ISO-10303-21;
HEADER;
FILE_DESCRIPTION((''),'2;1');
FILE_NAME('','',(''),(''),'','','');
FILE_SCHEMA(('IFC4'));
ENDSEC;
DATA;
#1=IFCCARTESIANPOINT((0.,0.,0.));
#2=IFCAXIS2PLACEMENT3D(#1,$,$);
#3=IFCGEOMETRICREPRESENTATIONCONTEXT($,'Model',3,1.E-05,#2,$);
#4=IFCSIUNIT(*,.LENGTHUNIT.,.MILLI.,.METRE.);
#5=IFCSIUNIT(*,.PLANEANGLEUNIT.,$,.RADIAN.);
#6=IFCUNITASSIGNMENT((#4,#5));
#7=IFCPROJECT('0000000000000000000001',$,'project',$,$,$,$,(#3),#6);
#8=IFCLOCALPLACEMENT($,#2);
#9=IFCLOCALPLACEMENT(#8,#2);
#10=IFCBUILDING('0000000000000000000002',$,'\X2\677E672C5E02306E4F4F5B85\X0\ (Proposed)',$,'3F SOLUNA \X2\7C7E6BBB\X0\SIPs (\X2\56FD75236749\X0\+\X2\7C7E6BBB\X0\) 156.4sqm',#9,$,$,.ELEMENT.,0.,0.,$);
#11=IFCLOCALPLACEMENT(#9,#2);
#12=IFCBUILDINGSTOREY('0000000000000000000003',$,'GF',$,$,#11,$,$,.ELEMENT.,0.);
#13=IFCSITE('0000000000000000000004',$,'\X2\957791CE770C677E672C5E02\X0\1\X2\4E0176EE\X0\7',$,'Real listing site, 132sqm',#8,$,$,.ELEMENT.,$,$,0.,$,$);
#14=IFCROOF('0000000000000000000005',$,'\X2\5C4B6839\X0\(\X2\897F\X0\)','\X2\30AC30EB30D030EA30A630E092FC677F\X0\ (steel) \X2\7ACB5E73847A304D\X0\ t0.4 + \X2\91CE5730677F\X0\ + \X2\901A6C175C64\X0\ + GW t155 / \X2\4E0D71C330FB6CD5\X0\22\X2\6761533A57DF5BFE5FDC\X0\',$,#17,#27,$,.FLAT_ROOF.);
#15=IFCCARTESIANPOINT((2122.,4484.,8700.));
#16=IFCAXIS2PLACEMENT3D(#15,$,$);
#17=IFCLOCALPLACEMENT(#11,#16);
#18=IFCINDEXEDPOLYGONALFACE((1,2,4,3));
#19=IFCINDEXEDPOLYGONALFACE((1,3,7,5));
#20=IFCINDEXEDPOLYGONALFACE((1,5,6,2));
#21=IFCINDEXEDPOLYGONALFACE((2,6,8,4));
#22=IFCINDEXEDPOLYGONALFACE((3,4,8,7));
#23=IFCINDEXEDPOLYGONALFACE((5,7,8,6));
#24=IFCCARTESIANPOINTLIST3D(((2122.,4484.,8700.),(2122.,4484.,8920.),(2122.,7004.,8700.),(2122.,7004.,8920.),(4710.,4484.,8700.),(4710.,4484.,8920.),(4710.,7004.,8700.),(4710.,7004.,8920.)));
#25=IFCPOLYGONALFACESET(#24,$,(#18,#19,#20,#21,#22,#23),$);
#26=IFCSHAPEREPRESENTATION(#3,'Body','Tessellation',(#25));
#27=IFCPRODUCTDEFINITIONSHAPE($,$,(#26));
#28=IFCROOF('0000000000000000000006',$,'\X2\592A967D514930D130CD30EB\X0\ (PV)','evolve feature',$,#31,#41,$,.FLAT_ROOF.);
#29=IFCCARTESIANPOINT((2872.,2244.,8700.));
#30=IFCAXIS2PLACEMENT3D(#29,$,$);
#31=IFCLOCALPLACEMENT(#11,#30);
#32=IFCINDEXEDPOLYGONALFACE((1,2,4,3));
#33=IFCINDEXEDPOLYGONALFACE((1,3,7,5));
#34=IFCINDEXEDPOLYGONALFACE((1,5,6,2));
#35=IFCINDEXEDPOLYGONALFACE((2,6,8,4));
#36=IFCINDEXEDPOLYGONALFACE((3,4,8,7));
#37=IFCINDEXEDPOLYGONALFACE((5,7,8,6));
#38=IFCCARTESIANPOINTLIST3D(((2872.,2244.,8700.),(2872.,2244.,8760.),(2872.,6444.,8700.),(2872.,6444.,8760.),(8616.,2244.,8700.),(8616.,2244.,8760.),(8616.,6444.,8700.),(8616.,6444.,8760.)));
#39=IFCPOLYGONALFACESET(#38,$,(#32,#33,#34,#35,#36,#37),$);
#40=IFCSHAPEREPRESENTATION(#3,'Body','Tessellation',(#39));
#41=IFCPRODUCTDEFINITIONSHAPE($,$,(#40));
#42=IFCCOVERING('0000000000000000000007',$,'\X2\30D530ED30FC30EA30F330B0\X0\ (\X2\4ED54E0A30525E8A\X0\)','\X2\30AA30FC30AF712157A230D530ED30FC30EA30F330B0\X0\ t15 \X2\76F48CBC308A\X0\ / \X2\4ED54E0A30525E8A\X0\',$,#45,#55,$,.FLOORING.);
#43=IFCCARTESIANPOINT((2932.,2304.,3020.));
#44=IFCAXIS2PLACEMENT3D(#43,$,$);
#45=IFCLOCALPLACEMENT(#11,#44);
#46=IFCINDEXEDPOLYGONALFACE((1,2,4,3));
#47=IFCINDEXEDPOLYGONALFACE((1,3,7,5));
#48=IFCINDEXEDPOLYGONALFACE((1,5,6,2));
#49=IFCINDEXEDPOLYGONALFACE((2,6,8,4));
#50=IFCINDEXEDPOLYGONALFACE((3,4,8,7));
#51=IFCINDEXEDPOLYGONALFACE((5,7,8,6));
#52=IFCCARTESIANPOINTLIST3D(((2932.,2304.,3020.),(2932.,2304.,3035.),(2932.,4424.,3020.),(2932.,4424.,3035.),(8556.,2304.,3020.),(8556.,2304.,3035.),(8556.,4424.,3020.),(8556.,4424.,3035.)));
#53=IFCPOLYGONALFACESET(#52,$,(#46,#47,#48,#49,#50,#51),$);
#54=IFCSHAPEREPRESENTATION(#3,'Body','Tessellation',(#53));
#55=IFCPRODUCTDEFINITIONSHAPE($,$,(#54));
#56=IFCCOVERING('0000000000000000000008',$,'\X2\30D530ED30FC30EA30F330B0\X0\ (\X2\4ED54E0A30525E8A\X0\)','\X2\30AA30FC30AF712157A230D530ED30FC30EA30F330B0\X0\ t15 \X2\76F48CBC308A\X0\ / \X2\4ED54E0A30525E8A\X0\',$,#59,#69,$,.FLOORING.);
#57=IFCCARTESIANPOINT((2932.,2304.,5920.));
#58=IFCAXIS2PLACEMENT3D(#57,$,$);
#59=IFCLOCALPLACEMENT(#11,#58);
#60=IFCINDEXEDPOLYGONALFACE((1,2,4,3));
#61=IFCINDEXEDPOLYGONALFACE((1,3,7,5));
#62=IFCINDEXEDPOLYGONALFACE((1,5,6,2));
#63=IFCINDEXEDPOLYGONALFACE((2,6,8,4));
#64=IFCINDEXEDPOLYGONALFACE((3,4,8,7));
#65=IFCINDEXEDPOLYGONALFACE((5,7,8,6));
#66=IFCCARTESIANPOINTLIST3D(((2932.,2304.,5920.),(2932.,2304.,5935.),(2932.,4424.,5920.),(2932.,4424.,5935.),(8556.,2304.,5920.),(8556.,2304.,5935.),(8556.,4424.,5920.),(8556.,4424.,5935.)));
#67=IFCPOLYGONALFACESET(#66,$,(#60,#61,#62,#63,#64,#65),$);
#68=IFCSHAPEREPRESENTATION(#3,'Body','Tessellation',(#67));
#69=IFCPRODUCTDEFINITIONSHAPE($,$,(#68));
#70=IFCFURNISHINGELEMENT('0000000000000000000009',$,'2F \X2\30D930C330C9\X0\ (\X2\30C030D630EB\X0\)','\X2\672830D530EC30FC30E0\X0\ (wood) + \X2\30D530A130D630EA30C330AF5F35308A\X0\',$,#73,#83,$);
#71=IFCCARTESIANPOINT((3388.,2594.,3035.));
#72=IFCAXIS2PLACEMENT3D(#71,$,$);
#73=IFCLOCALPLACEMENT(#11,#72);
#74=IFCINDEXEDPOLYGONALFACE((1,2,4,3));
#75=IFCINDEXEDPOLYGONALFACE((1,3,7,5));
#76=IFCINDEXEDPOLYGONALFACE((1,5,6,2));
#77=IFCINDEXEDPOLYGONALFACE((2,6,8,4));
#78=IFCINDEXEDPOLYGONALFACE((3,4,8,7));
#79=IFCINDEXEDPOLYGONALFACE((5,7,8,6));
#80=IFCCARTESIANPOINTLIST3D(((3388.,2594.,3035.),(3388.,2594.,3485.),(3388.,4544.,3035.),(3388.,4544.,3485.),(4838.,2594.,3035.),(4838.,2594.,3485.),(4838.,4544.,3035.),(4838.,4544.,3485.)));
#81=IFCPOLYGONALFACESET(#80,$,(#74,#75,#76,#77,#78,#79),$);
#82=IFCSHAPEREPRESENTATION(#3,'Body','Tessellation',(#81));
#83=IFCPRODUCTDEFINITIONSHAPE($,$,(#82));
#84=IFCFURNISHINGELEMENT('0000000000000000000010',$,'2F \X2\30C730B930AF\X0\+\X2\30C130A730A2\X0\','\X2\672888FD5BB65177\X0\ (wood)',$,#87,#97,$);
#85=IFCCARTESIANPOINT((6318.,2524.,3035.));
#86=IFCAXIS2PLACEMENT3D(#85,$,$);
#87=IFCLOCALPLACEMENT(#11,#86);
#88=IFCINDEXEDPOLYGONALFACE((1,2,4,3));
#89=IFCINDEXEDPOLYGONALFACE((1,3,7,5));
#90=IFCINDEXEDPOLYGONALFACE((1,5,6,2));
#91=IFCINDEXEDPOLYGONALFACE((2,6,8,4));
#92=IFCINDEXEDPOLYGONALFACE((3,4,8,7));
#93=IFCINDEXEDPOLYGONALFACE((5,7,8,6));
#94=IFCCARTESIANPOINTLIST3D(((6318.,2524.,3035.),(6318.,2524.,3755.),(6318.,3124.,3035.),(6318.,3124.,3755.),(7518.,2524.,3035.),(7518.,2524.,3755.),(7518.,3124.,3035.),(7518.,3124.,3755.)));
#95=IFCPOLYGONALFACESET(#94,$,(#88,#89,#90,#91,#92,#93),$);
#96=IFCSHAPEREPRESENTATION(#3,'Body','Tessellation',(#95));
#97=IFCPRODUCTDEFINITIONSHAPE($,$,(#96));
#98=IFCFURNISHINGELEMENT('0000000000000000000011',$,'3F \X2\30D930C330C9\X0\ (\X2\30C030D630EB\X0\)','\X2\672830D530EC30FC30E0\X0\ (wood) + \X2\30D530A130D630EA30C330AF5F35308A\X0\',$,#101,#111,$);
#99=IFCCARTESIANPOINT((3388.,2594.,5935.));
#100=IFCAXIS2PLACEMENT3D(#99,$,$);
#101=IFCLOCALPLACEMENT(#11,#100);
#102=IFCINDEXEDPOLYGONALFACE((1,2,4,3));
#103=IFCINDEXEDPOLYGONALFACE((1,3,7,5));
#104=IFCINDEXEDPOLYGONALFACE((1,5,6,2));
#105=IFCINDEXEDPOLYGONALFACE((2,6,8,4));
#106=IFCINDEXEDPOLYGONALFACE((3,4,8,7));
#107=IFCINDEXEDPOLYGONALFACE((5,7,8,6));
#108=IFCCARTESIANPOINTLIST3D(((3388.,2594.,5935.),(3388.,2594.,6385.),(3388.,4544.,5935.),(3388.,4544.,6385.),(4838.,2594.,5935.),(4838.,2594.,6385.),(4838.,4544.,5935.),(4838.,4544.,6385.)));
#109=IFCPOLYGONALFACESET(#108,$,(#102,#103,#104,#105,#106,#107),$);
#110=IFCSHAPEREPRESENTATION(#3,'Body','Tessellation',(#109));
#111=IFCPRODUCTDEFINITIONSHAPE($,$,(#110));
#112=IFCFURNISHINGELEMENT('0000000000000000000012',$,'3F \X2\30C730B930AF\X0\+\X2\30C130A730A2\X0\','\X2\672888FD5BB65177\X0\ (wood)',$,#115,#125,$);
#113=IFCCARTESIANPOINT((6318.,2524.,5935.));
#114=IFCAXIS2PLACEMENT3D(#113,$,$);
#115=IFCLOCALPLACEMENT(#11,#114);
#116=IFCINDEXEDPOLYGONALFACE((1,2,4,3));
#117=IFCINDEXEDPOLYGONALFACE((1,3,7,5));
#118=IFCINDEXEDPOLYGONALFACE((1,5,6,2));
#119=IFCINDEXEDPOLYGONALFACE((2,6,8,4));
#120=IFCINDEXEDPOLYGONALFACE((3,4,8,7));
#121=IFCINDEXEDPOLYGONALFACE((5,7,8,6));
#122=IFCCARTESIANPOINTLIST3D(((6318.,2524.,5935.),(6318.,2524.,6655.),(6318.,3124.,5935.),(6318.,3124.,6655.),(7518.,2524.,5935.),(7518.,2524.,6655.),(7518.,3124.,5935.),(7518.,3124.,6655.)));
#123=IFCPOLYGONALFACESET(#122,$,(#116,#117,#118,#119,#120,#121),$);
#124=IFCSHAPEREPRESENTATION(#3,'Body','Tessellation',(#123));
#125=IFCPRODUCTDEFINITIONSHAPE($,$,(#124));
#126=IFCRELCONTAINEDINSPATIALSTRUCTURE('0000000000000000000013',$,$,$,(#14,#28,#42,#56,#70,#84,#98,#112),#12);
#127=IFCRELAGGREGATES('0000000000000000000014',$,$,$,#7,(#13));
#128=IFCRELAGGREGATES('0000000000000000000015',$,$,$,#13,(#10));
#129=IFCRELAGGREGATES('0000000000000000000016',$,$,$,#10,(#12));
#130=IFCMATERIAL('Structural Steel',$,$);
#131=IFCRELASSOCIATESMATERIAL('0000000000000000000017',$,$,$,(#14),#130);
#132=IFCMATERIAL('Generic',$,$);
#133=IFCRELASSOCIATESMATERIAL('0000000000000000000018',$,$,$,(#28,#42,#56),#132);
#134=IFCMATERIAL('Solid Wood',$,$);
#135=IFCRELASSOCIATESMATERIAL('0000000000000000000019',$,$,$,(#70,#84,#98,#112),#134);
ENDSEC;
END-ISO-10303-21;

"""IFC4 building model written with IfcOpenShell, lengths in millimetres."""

from ifc_helpers import new_model, si_unit, frame, frame_2d, origin, place, context, project, spatial, rectangle, extrude, material, element, save


model = new_model("IFC4")

# Units and contexts
model_context = context("Model", 3, precision=1e-05, world=origin())
ifc_project = project(units=[si_unit("LENGTHUNIT", "METRE", prefix="MILLI"), si_unit("PLANEANGLEUNIT", "RADIAN")], contexts=[model_context])

# Site, building, storey
site_placement = place(None, origin())
site = spatial("IfcSite", under=ifc_project, at=site_placement, Name="長野県松本市1丁目7", ObjectType="Real listing site, 132sqm", CompositionType="ELEMENT", RefElevation=0.0)
building_placement = place(site_placement, origin())
building = spatial("IfcBuilding", under=site, at=building_placement, Name="松本市の住宅 (Proposed)", ObjectType="3F SOLUNA 籾殻SIPs (国産杉+籾殻) 156.4sqm", CompositionType="ELEMENT", ElevationOfRefHeight=0.0, ElevationOfTerrain=0.0)
storey_placement = place(building_placement, origin())
storey = spatial("IfcBuildingStorey", under=building, at=storey_placement, Name="GF", CompositionType="ELEMENT", Elevation=0.0)

# Shared definitions
ifc_material_1 = material(Name="Solid Wood")

# Roofs
ifc_material_2 = material(Name="Structural Steel")
roof_1_placement = place(storey_placement, frame((2122.0, 4484.0, 8700.0)))
element("IfcRoof", 1, at=roof_1_placement, inside=storey, material=ifc_material_2, Name="屋根(西)", Description="ガルバリウム鋼板 (steel) 立平葺き t0.4 + 野地板 + 通気層 + GW t155 / 不燃・法22条区域対応", PredefinedType="FLAT_ROOF", context=model_context, shape_type="SweptSolid", body=[
    extrude(rectangle(XDim=2588.0, YDim=2520.0, at=frame_2d((1294.0, 1260.0))), frame((2122.0, 4484.0, 8700.0)), (0.0, 0.0, 1.0), 220.0),
])
ifc_material_3 = material(Name="Generic")
roof_2_placement = place(storey_placement, frame((2872.0, 2244.0, 8700.0)))
element("IfcRoof", 2, at=roof_2_placement, inside=storey, material=ifc_material_3, Name="太陽光パネル (PV)", Description="evolve feature", PredefinedType="FLAT_ROOF", context=model_context, shape_type="SweptSolid", body=[
    extrude(rectangle(XDim=5744.0, YDim=4200.0, at=frame_2d((2872.0, 2100.0))), frame((2872.0, 2244.0, 8700.0)), (0.0, 0.0, 1.0), 60.0),
])

# Coverings
covering_1_placement = place(storey_placement, frame((2932.0, 2304.0, 3020.0)))
element("IfcCovering", 3, at=covering_1_placement, inside=storey, material=ifc_material_3, Name="フローリング (仕上げ床)", Description="オーク無垢フローリング t15 直貼り / 仕上げ床", PredefinedType="FLOORING", context=model_context, shape_type="SweptSolid", body=[
    extrude(rectangle(XDim=5624.0, YDim=2120.0, at=frame_2d((2812.0, 1060.0))), frame((2932.0, 2304.0, 3020.0)), (0.0, 0.0, 1.0), 15.0),
])
covering_2_placement = place(storey_placement, frame((2932.0, 2304.0, 5920.0)))
element("IfcCovering", 4, at=covering_2_placement, inside=storey, material=ifc_material_3, Name="フローリング (仕上げ床)", Description="オーク無垢フローリング t15 直貼り / 仕上げ床", PredefinedType="FLOORING", context=model_context, shape_type="SweptSolid", body=[
    extrude(rectangle(XDim=5624.0, YDim=2120.0, at=frame_2d((2812.0, 1060.0))), frame((2932.0, 2304.0, 5920.0)), (0.0, 0.0, 1.0), 15.0),
])

# Furnishing elements
furnishing_1_placement = place(storey_placement, frame((3388.0, 2594.0, 3035.0)))
element("IfcFurnishingElement", 5, at=furnishing_1_placement, inside=storey, material=ifc_material_1, Name="2F ベッド (ダブル)", Description="木フレーム (wood) + ファブリック張り", context=model_context, shape_type="SweptSolid", body=[
    extrude(rectangle(XDim=1450.0, YDim=1950.0, at=frame_2d((725.0, 975.0))), frame((3388.0, 2594.0, 3035.0)), (0.0, 0.0, 1.0), 450.0),
])
furnishing_2_placement = place(storey_placement, frame((6318.0, 2524.0, 3035.0)))
element("IfcFurnishingElement", 6, at=furnishing_2_placement, inside=storey, material=ifc_material_1, Name="2F デスク+チェア", Description="木製家具 (wood)", context=model_context, shape_type="SweptSolid", body=[
    extrude(rectangle(XDim=1200.0, YDim=600.0, at=frame_2d((600.0, 300.0))), frame((6318.0, 2524.0, 3035.0)), (0.0, 0.0, 1.0), 720.0),
])
furnishing_3_placement = place(storey_placement, frame((3388.0, 2594.0, 5935.0)))
element("IfcFurnishingElement", 7, at=furnishing_3_placement, inside=storey, material=ifc_material_1, Name="3F ベッド (ダブル)", Description="木フレーム (wood) + ファブリック張り", context=model_context, shape_type="SweptSolid", body=[
    extrude(rectangle(XDim=1450.0, YDim=1950.0, at=frame_2d((725.0, 975.0))), frame((3388.0, 2594.0, 5935.0)), (0.0, 0.0, 1.0), 450.0),
])
furnishing_4_placement = place(storey_placement, frame((6318.0, 2524.0, 5935.0)))
element("IfcFurnishingElement", 8, at=furnishing_4_placement, inside=storey, material=ifc_material_1, Name="3F デスク+チェア", Description="木製家具 (wood)", context=model_context, shape_type="SweptSolid", body=[
    extrude(rectangle(XDim=1200.0, YDim=600.0, at=frame_2d((600.0, 300.0))), frame((6318.0, 2524.0, 5935.0)), (0.0, 0.0, 1.0), 720.0),
])

save(model, "model.ifc")
